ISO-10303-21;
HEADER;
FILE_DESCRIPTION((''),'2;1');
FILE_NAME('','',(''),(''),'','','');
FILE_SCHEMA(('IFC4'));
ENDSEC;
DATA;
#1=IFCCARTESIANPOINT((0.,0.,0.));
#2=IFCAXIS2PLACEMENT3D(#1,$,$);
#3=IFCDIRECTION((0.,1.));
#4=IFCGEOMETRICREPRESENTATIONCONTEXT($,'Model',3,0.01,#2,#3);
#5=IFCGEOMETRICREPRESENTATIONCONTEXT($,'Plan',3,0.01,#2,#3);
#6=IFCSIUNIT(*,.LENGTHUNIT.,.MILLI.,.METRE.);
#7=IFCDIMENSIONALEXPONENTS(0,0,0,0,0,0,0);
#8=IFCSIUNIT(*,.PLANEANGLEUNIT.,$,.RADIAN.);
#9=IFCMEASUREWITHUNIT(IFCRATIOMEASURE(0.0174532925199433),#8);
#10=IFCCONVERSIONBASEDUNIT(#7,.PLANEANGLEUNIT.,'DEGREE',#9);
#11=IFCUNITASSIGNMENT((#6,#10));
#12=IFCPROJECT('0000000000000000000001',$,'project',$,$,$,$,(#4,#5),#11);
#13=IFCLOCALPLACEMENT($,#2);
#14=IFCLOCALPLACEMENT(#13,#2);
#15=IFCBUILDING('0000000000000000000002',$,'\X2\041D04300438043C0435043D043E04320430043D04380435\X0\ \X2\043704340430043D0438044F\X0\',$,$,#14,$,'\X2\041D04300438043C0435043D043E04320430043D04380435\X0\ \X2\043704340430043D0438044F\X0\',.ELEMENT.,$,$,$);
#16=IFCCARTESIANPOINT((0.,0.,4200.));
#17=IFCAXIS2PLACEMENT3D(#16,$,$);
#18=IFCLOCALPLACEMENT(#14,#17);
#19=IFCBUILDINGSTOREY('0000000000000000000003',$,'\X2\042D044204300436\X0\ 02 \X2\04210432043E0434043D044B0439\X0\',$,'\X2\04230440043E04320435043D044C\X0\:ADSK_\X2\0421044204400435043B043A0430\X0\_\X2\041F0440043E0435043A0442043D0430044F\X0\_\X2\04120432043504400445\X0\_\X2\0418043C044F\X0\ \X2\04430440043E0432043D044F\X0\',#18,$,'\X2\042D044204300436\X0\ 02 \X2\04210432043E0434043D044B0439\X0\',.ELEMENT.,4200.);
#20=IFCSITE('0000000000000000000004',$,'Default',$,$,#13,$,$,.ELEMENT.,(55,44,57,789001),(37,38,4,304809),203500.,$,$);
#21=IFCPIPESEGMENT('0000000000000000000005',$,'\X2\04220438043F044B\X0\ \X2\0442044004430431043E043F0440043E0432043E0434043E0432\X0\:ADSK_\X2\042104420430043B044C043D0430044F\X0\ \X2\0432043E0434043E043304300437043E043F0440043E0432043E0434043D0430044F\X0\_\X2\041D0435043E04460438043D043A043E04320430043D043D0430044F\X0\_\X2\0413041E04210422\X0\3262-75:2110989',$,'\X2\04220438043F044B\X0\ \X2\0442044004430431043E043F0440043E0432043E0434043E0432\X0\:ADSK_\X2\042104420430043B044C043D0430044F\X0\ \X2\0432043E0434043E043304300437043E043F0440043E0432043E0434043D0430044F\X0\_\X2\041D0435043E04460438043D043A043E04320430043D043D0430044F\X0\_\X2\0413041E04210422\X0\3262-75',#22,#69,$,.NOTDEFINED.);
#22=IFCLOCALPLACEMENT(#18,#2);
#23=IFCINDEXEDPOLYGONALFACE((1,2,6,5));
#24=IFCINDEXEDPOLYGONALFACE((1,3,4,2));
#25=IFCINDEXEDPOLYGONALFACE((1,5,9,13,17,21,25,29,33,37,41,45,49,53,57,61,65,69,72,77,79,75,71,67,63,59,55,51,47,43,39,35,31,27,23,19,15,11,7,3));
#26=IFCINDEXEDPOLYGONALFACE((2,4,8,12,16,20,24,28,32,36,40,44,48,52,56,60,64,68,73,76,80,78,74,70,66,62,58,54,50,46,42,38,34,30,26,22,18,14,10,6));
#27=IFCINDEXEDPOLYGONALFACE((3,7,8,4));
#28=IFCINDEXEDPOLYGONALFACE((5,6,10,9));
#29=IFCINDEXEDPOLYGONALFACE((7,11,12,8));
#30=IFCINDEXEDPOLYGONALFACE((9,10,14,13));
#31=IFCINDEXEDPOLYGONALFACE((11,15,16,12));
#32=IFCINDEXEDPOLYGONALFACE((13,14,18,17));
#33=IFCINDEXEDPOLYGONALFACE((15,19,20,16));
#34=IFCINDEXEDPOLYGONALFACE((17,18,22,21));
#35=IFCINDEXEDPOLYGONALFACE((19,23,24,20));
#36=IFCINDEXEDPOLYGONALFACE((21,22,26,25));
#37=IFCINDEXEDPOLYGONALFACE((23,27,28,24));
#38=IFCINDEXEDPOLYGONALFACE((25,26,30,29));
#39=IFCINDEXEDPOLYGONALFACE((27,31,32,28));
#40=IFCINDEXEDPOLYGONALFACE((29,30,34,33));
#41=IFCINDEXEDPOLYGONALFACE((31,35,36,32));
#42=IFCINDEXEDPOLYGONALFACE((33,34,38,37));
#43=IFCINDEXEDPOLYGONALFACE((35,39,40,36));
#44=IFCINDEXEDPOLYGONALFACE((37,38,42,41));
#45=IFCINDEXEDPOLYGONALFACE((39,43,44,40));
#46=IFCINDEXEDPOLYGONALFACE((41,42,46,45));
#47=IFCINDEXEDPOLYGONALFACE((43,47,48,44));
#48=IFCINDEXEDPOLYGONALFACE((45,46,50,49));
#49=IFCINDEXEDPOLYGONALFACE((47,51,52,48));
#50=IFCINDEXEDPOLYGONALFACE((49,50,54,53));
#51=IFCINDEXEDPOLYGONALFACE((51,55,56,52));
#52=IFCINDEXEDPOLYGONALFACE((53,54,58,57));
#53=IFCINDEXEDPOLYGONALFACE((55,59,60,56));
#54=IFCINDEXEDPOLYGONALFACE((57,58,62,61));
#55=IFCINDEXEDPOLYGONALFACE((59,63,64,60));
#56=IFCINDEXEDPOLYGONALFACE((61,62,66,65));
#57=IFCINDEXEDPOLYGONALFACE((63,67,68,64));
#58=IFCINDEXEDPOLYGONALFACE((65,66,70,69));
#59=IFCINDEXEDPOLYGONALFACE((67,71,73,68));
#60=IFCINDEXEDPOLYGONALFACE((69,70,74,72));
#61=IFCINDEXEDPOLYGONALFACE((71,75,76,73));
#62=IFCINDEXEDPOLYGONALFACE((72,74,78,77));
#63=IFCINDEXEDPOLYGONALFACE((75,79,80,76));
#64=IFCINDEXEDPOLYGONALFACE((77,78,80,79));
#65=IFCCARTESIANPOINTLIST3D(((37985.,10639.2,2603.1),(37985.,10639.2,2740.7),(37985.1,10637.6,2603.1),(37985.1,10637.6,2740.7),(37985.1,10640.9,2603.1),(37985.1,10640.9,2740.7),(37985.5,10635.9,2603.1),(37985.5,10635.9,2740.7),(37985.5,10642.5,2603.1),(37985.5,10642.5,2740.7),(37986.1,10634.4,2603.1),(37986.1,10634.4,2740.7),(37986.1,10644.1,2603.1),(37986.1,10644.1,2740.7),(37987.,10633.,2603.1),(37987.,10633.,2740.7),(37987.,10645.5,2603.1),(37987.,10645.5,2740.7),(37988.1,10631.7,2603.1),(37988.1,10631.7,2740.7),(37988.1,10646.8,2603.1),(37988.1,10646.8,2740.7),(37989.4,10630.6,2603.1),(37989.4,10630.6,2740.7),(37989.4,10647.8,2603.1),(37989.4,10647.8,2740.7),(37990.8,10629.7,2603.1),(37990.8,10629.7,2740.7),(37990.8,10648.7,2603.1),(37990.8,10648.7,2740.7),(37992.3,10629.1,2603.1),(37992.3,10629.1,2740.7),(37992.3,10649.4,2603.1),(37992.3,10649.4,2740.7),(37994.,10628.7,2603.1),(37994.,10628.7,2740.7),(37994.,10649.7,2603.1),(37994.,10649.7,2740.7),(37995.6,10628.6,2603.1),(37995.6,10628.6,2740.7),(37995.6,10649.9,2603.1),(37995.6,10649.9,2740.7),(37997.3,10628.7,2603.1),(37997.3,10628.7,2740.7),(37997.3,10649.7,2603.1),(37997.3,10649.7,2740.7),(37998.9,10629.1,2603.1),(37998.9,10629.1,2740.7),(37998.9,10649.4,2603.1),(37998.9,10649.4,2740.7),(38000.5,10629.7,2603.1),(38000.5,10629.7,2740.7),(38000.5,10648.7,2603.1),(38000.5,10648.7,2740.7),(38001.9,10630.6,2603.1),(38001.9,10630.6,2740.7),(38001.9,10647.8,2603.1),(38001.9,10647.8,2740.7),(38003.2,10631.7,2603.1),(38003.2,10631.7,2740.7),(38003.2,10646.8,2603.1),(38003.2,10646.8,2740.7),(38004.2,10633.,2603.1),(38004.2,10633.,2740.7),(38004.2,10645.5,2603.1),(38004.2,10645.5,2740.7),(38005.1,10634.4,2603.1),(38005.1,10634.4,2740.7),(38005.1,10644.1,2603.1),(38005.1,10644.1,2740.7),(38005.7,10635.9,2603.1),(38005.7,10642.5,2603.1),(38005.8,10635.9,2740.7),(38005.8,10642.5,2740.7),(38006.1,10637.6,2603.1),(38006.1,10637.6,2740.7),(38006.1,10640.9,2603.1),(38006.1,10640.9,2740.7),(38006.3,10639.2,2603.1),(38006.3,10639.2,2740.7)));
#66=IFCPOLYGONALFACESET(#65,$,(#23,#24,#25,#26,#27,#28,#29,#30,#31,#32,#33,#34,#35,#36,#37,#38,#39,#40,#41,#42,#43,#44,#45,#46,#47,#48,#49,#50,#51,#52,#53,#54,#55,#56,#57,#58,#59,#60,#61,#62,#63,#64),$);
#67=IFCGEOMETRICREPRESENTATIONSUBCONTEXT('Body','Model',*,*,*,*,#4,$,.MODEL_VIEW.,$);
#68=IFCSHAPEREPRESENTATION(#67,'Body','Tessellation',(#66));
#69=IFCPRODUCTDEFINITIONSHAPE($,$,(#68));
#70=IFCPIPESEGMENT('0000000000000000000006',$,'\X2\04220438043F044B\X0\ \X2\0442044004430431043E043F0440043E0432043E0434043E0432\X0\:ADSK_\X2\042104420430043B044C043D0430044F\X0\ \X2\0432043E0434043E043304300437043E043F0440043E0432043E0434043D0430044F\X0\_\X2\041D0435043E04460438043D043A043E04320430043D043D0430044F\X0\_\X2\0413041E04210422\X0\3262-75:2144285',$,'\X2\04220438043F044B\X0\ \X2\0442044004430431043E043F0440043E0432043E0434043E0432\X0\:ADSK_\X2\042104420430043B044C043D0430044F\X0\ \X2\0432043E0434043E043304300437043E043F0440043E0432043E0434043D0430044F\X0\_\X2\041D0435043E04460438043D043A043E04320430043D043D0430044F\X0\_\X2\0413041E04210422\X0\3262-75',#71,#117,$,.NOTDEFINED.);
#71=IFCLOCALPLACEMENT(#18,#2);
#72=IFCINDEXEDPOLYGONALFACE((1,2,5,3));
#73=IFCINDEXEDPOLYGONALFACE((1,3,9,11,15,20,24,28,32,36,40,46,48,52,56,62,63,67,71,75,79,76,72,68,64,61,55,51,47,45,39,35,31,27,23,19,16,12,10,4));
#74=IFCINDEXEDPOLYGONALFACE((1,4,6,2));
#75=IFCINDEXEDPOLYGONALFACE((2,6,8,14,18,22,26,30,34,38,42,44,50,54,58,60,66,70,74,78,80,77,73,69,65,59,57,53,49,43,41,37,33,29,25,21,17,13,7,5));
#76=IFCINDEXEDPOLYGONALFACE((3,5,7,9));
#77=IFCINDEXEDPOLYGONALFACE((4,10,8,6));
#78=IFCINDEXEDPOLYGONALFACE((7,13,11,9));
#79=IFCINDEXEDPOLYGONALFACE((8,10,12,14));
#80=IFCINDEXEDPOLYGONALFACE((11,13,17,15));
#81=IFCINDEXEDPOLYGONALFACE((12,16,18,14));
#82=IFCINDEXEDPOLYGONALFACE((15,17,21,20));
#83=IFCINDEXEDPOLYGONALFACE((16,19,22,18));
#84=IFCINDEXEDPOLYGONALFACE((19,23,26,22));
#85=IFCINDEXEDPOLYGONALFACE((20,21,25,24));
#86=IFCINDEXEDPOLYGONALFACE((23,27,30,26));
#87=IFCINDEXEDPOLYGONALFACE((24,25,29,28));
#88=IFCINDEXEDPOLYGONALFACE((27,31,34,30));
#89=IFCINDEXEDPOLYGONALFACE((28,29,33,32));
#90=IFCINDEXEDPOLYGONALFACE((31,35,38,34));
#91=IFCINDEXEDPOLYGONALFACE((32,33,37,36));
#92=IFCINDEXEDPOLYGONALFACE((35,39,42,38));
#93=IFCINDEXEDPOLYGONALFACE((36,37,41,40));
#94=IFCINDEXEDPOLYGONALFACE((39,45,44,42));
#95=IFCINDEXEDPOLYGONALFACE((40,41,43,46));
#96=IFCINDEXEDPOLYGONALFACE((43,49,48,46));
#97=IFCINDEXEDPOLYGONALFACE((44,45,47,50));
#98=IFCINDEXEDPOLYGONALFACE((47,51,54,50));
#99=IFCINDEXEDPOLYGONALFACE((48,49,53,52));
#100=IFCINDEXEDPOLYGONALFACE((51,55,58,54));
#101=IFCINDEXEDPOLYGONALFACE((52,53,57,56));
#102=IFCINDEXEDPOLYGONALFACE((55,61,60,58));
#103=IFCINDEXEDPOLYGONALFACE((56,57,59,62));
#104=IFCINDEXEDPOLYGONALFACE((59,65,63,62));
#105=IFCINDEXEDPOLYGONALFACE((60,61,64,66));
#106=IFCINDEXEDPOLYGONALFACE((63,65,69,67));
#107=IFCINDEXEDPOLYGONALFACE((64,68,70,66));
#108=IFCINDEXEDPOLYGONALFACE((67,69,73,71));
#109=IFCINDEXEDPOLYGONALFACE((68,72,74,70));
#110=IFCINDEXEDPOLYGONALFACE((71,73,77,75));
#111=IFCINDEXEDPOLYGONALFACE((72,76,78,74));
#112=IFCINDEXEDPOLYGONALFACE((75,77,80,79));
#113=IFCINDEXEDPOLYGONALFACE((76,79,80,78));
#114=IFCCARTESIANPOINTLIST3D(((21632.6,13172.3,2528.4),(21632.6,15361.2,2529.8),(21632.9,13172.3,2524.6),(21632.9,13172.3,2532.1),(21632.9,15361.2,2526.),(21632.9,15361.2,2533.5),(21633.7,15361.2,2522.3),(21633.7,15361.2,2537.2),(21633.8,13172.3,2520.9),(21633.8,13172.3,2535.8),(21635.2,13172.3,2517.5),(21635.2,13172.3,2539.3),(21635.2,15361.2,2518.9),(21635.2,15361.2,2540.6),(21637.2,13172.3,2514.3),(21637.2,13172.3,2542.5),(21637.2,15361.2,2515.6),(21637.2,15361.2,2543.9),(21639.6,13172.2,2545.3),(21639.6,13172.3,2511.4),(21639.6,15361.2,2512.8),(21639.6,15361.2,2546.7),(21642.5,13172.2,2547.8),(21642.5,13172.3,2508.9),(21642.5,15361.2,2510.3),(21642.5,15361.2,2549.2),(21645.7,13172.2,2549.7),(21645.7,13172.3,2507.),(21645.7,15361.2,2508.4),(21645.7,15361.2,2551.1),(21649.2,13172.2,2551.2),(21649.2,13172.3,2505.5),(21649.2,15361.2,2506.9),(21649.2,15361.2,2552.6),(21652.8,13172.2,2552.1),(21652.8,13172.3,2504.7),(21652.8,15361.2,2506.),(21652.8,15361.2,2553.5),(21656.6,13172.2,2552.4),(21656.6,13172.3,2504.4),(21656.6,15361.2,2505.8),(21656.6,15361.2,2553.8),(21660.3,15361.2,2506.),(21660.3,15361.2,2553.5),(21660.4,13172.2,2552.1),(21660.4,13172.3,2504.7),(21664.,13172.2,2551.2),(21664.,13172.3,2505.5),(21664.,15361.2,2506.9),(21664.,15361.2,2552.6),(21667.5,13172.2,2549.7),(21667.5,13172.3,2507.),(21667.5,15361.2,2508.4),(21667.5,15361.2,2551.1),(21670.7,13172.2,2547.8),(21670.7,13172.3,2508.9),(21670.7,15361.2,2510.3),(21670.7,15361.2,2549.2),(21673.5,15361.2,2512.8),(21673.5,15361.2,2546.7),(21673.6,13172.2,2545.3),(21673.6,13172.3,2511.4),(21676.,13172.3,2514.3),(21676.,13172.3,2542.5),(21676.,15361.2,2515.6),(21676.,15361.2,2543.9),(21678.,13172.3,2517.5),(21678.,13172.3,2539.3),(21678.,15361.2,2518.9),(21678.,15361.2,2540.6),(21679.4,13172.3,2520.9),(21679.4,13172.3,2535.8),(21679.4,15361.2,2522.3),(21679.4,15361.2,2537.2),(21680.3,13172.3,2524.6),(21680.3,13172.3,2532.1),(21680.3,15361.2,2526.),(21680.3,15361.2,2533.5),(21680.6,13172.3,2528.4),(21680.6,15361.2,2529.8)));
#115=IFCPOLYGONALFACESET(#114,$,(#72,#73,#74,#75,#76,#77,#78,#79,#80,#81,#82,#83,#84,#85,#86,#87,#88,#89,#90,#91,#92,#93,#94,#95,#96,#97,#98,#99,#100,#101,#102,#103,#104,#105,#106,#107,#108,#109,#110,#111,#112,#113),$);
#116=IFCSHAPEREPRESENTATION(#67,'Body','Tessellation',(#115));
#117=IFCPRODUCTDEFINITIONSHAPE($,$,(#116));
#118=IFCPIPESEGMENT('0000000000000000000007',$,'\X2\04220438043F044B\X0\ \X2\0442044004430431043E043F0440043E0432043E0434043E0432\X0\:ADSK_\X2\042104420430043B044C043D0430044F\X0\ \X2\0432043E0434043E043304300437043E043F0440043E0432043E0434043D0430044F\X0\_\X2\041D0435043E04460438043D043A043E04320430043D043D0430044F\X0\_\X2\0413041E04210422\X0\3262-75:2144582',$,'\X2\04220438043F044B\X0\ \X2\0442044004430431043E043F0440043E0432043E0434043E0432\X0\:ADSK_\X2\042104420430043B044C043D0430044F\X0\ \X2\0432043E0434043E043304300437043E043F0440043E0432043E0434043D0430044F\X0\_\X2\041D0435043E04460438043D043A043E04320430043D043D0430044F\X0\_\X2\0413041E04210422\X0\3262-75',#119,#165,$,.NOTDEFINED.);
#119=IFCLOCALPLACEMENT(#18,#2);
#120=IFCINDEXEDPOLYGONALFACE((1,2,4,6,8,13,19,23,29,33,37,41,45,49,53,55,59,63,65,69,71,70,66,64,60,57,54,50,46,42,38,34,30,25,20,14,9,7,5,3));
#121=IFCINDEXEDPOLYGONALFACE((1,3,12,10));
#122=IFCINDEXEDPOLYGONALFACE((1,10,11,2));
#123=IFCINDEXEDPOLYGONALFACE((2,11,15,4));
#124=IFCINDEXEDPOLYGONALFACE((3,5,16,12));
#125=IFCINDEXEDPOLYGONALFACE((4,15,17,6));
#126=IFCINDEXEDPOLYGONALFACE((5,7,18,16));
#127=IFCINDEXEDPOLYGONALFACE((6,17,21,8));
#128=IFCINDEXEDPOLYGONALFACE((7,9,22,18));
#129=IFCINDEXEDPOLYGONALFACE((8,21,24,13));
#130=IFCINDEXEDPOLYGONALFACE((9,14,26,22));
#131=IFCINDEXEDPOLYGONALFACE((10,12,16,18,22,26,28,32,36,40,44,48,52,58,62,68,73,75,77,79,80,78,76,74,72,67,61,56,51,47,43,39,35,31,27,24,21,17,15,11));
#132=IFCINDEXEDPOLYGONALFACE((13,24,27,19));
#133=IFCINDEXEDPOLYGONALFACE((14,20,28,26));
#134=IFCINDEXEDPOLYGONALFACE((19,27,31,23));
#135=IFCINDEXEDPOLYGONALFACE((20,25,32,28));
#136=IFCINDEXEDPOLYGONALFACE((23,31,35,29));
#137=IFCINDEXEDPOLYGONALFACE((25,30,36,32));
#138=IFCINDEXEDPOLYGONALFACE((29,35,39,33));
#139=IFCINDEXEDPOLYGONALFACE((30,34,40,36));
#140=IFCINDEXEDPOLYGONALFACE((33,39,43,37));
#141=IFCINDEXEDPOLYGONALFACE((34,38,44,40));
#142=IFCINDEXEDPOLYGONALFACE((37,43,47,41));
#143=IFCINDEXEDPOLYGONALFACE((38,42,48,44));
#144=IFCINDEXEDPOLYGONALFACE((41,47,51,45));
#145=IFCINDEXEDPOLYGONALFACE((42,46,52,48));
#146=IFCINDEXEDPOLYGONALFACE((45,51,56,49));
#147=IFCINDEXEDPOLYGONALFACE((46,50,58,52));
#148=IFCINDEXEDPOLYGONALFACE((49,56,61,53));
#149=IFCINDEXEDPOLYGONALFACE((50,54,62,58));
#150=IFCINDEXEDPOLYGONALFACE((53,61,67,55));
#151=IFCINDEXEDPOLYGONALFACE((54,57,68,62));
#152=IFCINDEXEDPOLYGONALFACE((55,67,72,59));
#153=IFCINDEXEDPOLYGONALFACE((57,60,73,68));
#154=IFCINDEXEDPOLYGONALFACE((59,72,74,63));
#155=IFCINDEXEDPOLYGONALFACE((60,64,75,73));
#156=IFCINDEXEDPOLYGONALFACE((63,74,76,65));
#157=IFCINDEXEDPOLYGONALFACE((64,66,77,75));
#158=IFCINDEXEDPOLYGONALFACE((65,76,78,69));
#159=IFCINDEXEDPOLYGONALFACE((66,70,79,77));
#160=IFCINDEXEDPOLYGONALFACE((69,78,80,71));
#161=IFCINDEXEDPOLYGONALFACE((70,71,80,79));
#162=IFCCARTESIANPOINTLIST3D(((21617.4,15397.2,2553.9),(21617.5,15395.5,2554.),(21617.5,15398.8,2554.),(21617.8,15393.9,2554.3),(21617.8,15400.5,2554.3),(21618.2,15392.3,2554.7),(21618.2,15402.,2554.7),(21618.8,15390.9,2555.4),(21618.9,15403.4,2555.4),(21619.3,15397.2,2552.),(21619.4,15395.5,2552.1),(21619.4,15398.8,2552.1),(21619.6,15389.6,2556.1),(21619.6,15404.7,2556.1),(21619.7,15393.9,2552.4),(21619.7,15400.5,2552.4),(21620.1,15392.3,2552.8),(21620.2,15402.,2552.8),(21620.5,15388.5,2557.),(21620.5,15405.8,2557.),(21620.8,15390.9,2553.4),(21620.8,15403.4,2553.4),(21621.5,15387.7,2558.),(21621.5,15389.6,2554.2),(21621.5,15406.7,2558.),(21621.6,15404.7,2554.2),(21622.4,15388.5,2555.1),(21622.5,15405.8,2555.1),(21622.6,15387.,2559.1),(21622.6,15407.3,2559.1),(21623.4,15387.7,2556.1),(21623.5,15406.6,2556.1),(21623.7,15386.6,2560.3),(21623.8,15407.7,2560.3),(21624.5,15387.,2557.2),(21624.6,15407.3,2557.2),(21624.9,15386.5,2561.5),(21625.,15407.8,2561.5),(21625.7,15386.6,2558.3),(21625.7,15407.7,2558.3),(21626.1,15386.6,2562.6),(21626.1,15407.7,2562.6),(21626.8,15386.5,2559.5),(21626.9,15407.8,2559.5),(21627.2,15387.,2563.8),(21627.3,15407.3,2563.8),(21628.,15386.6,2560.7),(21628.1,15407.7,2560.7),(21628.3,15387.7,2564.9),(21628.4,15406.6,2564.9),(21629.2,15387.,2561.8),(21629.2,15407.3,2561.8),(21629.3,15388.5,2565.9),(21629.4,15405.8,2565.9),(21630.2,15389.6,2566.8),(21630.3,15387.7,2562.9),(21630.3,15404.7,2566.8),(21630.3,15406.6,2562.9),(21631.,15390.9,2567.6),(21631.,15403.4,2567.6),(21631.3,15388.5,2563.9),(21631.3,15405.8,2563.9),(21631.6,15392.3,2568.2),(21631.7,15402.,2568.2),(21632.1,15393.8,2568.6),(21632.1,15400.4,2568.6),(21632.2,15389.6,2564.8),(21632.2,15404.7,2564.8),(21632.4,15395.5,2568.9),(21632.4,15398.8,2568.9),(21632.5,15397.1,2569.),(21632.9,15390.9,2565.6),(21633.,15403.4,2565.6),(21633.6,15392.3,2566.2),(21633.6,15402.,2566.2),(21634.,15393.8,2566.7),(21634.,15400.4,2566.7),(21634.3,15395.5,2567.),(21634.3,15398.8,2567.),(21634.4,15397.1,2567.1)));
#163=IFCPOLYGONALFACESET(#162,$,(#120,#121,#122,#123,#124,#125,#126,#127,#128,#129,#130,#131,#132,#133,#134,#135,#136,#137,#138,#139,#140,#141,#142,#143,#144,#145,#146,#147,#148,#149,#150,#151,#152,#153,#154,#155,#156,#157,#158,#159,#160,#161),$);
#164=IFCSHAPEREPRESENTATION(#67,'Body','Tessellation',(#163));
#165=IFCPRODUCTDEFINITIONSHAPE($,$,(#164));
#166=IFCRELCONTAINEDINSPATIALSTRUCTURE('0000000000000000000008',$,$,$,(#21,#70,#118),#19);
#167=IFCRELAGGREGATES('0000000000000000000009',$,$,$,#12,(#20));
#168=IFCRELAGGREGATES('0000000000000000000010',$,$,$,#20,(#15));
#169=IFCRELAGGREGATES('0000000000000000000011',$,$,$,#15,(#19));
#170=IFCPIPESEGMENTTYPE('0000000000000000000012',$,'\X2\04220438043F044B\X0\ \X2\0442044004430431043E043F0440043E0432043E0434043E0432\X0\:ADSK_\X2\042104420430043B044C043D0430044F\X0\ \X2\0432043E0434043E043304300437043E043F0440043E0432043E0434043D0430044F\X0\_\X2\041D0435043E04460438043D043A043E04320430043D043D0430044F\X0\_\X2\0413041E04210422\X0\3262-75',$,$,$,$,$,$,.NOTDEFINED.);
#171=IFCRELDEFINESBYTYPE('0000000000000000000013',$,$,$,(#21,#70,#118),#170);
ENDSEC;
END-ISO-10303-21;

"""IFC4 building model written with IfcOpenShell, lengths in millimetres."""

from ifc_helpers import new_model, entity, si_unit, converted_unit, direction, frame, origin, place, context, subcontext, project, spatial, indexed_curve, outline, extrude, type_object, element, save


model = new_model("IFC4")

# Units and contexts
model_context = context("Model", 3, precision=0.01, world=origin(), true_north=direction((0.0, 1.0)))
plan_context = context("Plan", 3, precision=0.01, world=origin(), true_north=direction((0.0, 1.0)))
body_context = subcontext(model_context, "Body", "Model", "MODEL_VIEW")
ifc_project = project(units=[si_unit("LENGTHUNIT", "METRE", prefix="MILLI"), converted_unit("PLANEANGLEUNIT", "DEGREE", entity("IfcRatioMeasure", 0.0174532925199433), si_unit("PLANEANGLEUNIT", "RADIAN"), dimensions=[0, 0, 0, 0, 0, 0, 0])], contexts=[model_context, plan_context])

# Site, building, storey
site_placement = place(None, origin())
site = spatial("IfcSite", under=ifc_project, at=site_placement, Name="Default", CompositionType="ELEMENT", RefLatitude=(55, 44, 57, 789001), RefLongitude=(37, 38, 4, 304809), RefElevation=203500.0)
building_placement = place(site_placement, origin())
building = spatial("IfcBuilding", under=site, at=building_placement, Name="Наименование здания", LongName="Наименование здания", CompositionType="ELEMENT")
storey_placement = place(building_placement, frame((0.0, 0.0, 4200.0)))
storey = spatial("IfcBuildingStorey", under=building, at=storey_placement, Name="Этаж 02 Сводный", ObjectType="Уровень:ADSK_Стрелка_Проектная_Вверх_Имя уровня", LongName="Этаж 02 Сводный", CompositionType="ELEMENT", Elevation=4200.0)

# Pipe segments
placement = place(storey_placement, origin())
pipe_segment_type_1 = type_object("IfcPipeSegmentType", Name="Типы трубопроводов:ADSK_Стальная водогазопроводная_Неоцинкованная_ГОСТ3262-75", PredefinedType="NOTDEFINED")
element("IfcPipeSegment", 1, at=placement, inside=storey, type_object=pipe_segment_type_1, Name="Типы трубопроводов:ADSK_Стальная водогазопроводная_Неоцинкованная_ГОСТ3262-75:2110989", ObjectType="Типы трубопроводов:ADSK_Стальная водогазопроводная_Неоцинкованная_ГОСТ3262-75", PredefinedType="NOTDEFINED", context=body_context, shape_type="SweptSolid", body=[
    extrude(outline(indexed_curve([(10.6, 0.0), (10.5, 1.7), (10.1, 3.3), (9.5, 4.8), (8.6, 6.3), (7.5, 7.5), (6.3, 8.6), (4.8, 9.5), (3.3, 10.1), (1.7, 10.5), (0.0, 10.7), (-1.7, 10.5), (-3.3, 10.1), (-4.8, 9.5), (-6.3, 8.6), (-7.5, 7.5), (-8.6, 6.3), (-9.5, 4.8), (-10.1, 3.3), (-10.5, 1.7), (-10.6, 0.0), (-10.5, -1.7), (-10.1, -3.3), (-9.5, -4.8), (-8.6, -6.3), (-7.5, -7.5), (-6.3, -8.6), (-4.8, -9.5), (-3.3, -10.1), (-1.7, -10.5), (0.0, -10.7), (1.7, -10.5), (3.3, -10.1), (4.8, -9.5), (6.3, -8.6), (7.5, -7.5), (8.6, -6.3), (9.5, -4.8), (10.1, -3.3), (10.5, -1.7), (10.6, 0.0)], self_intersect=False)), frame((37995.6, 10639.2, 2603.1), z_axis=(0.000021, -0.000019, 1.0), x_axis=(-1.0, 0.0, 0.000021)), (0.0, 0.0, 1.0), 137.7),
])
element("IfcPipeSegment", 2, at=placement, inside=storey, type_object=pipe_segment_type_1, Name="Типы трубопроводов:ADSK_Стальная водогазопроводная_Неоцинкованная_ГОСТ3262-75:2144285", ObjectType="Типы трубопроводов:ADSK_Стальная водогазопроводная_Неоцинкованная_ГОСТ3262-75", PredefinedType="NOTDEFINED", context=body_context, shape_type="SweptSolid", body=[
    extrude(outline(indexed_curve([(24.0, 0.0), (23.7, 3.8), (22.8, 7.4), (21.4, 10.9), (19.4, 14.1), (17.0, 17.0), (14.1, 19.4), (10.9, 21.4), (7.4, 22.8), (3.8, 23.7), (0.0, 24.0), (-3.8, 23.7), (-7.4, 22.8), (-10.9, 21.4), (-14.1, 19.4), (-17.0, 17.0), (-19.4, 14.1), (-21.4, 10.9), (-22.8, 7.4), (-23.7, 3.8), (-24.0, 0.0), (-23.7, -3.8), (-22.8, -7.4), (-21.4, -10.9), (-19.4, -14.1), (-17.0, -17.0), (-14.1, -19.4), (-10.9, -21.4), (-7.4, -22.8), (-3.8, -23.7), (0.0, -24.0), (3.8, -23.7), (7.4, -22.8), (10.9, -21.4), (14.1, -19.4), (17.0, -17.0), (19.4, -14.1), (21.4, -10.9), (22.8, -7.4), (23.7, -3.8), (24.0, 0.0)], self_intersect=False)), frame((21656.6, 13172.3, 2528.4), z_axis=(-0.000012, 1.0, 0.000636), x_axis=(1.0, 0.000012, 0.0)), (0.0, 0.0, 1.0), 2188.9),
])
element("IfcPipeSegment", 3, at=placement, inside=storey, type_object=pipe_segment_type_1, Name="Типы трубопроводов:ADSK_Стальная водогазопроводная_Неоцинкованная_ГОСТ3262-75:2144582", ObjectType="Типы трубопроводов:ADSK_Стальная водогазопроводная_Неоцинкованная_ГОСТ3262-75", PredefinedType="NOTDEFINED", context=body_context, shape_type="SweptSolid", body=[
    extrude(outline(indexed_curve([(10.7, 0.0), (10.5, 1.7), (10.1, 3.3), (9.5, 4.8), (8.6, 6.3), (7.5, 7.5), (6.3, 8.6), (4.8, 9.5), (3.3, 10.1), (1.7, 10.5), (0.0, 10.7), (-1.7, 10.5), (-3.3, 10.1), (-4.8, 9.5), (-6.3, 8.6), (-7.5, 7.5), (-8.6, 6.3), (-9.5, 4.8), (-10.1, 3.3), (-10.5, 1.7), (-10.7, 0.0), (-10.5, -1.7), (-10.1, -3.3), (-9.5, -4.8), (-8.6, -6.3), (-7.5, -7.5), (-6.3, -8.6), (-4.8, -9.5), (-3.3, -10.1), (-1.7, -10.5), (0.0, -10.6), (1.7, -10.5), (3.3, -10.1), (4.8, -9.5), (6.3, -8.6), (7.5, -7.5), (8.6, -6.3), (9.5, -4.8), (10.1, -3.3), (10.5, -1.7), (10.7, 0.0)], self_intersect=False)), frame((21626.9, 15397.1, 2559.5), z_axis=(-0.707106, 0.001611, 0.707106), x_axis=(0.002279, 0.999997, 0.0)), (0.0, 0.0, 1.0), 2.7),
])

save(model, "model.ifc")
